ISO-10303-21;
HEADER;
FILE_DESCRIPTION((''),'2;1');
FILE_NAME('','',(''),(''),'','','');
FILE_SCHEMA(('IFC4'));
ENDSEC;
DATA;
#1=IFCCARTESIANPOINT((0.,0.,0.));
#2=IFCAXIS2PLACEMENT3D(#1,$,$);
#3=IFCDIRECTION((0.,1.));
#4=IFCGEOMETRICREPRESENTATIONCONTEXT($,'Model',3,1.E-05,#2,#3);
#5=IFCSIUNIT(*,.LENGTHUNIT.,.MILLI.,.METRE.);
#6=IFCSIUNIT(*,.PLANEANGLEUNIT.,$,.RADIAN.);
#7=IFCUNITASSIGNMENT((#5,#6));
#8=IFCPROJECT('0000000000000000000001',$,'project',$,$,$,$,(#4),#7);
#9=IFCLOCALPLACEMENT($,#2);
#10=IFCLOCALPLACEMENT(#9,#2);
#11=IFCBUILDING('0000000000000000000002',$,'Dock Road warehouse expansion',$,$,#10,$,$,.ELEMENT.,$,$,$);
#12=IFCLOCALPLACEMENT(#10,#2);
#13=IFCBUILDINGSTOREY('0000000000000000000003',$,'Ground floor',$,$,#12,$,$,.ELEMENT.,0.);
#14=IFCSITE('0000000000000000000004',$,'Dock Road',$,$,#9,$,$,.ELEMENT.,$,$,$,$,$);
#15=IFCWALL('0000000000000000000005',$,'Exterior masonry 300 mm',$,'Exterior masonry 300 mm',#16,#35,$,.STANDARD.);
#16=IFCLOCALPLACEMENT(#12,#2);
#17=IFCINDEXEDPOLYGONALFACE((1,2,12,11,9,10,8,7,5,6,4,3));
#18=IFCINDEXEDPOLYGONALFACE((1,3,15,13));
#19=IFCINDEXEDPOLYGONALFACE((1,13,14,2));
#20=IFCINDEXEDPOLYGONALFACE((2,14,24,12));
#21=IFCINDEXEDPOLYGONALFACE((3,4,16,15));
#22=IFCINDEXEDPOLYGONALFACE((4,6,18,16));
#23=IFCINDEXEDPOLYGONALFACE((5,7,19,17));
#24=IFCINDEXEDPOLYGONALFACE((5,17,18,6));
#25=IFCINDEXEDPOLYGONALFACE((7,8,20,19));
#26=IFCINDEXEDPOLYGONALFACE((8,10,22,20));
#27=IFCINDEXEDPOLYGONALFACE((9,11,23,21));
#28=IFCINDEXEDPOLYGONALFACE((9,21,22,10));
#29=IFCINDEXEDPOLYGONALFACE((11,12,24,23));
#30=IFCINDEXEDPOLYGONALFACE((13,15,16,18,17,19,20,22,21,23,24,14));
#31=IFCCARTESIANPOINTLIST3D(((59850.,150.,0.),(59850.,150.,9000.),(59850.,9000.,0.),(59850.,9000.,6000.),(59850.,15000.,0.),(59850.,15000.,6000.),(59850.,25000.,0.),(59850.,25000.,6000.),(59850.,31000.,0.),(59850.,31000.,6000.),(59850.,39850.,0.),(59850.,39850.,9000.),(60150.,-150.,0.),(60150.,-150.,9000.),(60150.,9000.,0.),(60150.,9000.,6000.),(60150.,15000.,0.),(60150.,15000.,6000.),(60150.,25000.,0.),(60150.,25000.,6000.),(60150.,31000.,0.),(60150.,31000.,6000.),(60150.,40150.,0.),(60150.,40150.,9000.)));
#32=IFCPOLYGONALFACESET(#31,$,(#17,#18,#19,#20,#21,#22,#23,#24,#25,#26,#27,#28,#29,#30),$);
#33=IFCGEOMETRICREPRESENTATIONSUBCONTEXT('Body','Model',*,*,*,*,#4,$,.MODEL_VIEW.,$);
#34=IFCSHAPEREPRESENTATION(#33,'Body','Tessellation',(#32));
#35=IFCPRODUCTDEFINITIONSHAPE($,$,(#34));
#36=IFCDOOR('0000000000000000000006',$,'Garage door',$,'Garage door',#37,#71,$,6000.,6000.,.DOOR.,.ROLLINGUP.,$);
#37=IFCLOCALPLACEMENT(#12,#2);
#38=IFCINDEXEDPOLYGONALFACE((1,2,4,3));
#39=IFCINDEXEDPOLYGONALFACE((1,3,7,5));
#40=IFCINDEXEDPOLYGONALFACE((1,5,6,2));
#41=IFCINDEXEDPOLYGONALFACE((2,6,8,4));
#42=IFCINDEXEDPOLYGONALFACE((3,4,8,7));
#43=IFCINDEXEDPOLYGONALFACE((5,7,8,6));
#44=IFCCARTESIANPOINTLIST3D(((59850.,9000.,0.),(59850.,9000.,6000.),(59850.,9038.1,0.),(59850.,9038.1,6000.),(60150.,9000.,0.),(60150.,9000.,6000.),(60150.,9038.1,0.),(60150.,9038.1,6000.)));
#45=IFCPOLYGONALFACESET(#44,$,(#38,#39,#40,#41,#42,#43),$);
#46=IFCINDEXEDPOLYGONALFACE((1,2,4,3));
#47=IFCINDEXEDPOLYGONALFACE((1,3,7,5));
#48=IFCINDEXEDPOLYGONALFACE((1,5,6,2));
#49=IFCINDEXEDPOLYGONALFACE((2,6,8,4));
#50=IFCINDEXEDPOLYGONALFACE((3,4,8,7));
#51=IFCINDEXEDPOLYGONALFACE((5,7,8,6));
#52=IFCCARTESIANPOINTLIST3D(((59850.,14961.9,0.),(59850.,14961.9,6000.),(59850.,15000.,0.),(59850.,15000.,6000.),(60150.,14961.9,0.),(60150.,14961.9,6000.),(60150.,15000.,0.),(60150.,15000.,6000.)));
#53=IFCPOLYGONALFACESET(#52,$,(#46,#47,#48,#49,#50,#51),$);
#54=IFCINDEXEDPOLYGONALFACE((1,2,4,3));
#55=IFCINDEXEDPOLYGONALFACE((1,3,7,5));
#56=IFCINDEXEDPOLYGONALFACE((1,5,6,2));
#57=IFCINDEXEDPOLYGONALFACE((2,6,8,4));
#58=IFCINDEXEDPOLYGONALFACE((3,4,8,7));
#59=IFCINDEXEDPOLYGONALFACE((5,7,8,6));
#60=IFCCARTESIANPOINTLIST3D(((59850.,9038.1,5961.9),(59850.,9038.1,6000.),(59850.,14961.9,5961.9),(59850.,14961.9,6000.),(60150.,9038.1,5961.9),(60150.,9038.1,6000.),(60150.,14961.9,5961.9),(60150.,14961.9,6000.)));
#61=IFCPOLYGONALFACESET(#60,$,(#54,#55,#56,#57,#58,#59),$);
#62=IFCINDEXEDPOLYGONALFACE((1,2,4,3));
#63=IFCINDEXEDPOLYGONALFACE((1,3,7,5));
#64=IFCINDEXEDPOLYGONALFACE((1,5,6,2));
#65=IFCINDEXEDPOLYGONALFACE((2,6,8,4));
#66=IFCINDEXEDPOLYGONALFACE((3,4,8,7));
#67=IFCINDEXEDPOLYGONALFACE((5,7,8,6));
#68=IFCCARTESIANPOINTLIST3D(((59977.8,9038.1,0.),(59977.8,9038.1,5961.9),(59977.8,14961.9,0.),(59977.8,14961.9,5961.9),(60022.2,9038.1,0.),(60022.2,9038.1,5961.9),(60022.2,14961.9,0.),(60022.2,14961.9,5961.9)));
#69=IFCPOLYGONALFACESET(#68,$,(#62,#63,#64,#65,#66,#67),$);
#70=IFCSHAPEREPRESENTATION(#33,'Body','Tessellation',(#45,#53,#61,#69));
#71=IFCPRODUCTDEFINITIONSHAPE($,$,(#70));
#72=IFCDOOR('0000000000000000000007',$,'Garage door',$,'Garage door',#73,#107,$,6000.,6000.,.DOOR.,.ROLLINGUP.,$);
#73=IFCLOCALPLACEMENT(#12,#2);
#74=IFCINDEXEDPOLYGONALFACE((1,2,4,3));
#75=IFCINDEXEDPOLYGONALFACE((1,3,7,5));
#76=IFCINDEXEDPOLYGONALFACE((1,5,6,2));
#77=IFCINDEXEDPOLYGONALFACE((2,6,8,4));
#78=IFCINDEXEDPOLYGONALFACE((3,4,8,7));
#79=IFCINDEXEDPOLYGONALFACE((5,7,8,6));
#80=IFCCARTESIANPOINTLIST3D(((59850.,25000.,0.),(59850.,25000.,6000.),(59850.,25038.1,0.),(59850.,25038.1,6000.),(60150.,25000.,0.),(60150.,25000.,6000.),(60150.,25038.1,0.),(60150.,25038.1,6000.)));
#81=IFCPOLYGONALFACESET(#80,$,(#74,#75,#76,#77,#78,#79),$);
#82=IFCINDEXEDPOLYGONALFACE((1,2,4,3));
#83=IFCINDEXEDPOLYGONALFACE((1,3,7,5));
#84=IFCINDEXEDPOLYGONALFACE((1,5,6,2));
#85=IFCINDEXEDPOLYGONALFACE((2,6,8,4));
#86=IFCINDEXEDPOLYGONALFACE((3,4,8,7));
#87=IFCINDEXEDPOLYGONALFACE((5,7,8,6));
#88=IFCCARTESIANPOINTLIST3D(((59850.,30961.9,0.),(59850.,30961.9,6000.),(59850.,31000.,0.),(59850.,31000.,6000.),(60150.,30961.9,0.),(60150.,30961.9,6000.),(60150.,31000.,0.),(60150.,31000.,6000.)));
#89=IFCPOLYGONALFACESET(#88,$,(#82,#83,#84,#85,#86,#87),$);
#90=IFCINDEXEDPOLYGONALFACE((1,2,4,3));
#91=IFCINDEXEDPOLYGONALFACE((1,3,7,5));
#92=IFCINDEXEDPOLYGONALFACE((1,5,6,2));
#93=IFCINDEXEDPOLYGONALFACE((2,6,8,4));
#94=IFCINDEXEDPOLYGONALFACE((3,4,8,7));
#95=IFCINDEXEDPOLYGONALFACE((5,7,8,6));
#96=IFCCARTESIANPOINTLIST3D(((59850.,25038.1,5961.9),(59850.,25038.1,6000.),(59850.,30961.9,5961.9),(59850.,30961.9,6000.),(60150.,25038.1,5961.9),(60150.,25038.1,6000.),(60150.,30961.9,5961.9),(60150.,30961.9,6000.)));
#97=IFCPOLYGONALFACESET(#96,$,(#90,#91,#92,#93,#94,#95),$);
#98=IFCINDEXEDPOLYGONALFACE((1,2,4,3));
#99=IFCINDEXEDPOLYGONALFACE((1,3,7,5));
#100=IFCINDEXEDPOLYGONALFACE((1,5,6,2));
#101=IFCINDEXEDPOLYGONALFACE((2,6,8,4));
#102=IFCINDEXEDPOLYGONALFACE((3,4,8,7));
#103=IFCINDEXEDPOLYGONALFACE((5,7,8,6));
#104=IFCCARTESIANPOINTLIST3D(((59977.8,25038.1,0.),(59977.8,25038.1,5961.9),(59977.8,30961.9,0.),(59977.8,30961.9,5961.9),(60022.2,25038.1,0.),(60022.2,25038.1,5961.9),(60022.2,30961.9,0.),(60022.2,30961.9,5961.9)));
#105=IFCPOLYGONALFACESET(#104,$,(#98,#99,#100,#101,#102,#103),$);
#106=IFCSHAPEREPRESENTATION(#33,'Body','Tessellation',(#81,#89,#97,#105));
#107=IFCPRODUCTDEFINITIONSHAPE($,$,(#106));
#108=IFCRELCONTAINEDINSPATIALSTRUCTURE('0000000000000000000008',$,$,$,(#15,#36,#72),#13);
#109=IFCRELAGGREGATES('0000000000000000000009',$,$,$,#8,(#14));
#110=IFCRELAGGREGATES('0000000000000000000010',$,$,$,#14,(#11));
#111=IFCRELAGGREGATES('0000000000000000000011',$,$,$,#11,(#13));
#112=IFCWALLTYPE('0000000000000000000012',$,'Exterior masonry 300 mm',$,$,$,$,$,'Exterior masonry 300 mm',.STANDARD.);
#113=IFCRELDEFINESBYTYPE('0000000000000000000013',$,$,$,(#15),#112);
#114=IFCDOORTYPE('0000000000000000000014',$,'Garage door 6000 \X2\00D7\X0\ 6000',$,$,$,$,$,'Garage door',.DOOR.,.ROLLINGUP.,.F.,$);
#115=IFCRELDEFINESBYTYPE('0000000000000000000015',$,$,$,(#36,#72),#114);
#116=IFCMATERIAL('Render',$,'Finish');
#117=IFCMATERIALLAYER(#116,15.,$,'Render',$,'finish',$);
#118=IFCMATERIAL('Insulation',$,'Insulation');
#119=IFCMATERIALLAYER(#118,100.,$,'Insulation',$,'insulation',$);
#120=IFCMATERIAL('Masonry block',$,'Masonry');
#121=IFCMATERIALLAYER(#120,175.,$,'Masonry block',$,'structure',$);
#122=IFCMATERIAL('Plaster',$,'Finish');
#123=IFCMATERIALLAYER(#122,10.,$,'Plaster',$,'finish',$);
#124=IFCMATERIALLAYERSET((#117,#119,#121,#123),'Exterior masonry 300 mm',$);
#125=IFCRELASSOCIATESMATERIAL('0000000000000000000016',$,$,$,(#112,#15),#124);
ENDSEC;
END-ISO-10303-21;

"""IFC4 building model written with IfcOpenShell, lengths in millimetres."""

from ifc_helpers import new_model, si_unit, direction, frame, origin, origin_with_axes, place, context, subcontext, project, spatial, polyline, outline, extrude, material, layer, layer_set, layer_usage, type_object, element, fill, save


model = new_model("IFC4")

# Units and contexts
model_context = context("Model", 3, precision=1e-05, world=origin(), true_north=direction((0.0, 1.0)))
body_context = subcontext(model_context, "Body", "Model", "MODEL_VIEW")
ifc_project = project(units=[si_unit("LENGTHUNIT", "METRE", prefix="MILLI"), si_unit("PLANEANGLEUNIT", "RADIAN")], contexts=[model_context])

# Site, building, storey
site_placement = place(None, origin())
site = spatial("IfcSite", under=ifc_project, at=site_placement, Name="Dock Road", CompositionType="ELEMENT")
building_placement = place(site_placement, origin())
building = spatial("IfcBuilding", under=site, at=building_placement, Name="Dock Road warehouse expansion", CompositionType="ELEMENT")
storey_placement = place(building_placement, origin())
storey = spatial("IfcBuildingStorey", under=building, at=storey_placement, Name="Ground floor", CompositionType="ELEMENT", Elevation=0.0)

# Shared definitions
ifc_material_1 = material(Name="Render", Category="Finish")
ifc_layer_1 = layer(ifc_material_1, 15.0, Name="Render", Category="finish")
ifc_material_2 = material(Name="Insulation", Category="Insulation")
ifc_layer_2 = layer(ifc_material_2, 100.0, Name="Insulation", Category="insulation")
ifc_material_3 = material(Name="Masonry block", Category="Masonry")
ifc_layer_3 = layer(ifc_material_3, 175.0, Name="Masonry block", Category="structure")
ifc_material_4 = material(Name="Plaster", Category="Finish")
ifc_layer_4 = layer(ifc_material_4, 10.0, Name="Plaster", Category="finish")
ifc_layer_set = layer_set([ifc_layer_1, ifc_layer_2, ifc_layer_3, ifc_layer_4], Name="Exterior masonry 300 mm")
wall_type = type_object("IfcWallType", Name="Exterior masonry 300 mm", ElementType="Exterior masonry 300 mm", PredefinedType="STANDARD", material=ifc_layer_set)

# Wall, openings, doors
ifc_layer_usage_1 = layer_usage(ifc_layer_set, "AXIS2", "POSITIVE", -150.0)
wall_1_placement = place(storey_placement, frame((60000.0, 0.0, 0.0), z_axis=(0.0, 0.0, 1.0), x_axis=(0.0, 1.0, 0.0)))
wall_1 = element("IfcWall", 1, at=wall_1_placement, inside=storey, type_object=wall_type, material=ifc_layer_usage_1, Name="Exterior masonry 300 mm", ObjectType="Exterior masonry 300 mm", PredefinedType="STANDARD", context=body_context, shape_type="SweptSolid", body=[
    extrude(outline(polyline([(-150.0, -150.0), (40150.0, -150.0), (39850.0, 150.0), (150.0, 150.0), (-150.0, -150.0)])), origin(), (0.0, 0.0, 1.0), 9000.0),
])
opening_1_placement = place(wall_1_placement, frame((9000.0, 0.0, 0.0), z_axis=(0.0, 0.0, 1.0), x_axis=(1.0, 0.0, 0.0)))
opening_1 = element("IfcOpeningElement", 2, at=opening_1_placement, cuts=wall_1, PredefinedType="OPENING", context=body_context, shape_type="SweptSolid", body=[
    extrude(outline(polyline([(0.0, -160.0), (6000.0, -160.0), (6000.0, 160.0), (0.0, 160.0), (0.0, -160.0)])), origin(), (0.0, 0.0, 1.0), 6000.0),
])
opening_2_placement = place(wall_1_placement, frame((25000.0, 0.0, 0.0), z_axis=(0.0, 0.0, 1.0), x_axis=(1.0, 0.0, 0.0)))
opening_2 = element("IfcOpeningElement", 3, at=opening_2_placement, cuts=wall_1, PredefinedType="OPENING", context=body_context, shape_type="SweptSolid", body=[
    extrude(outline(polyline([(0.0, -160.0), (6000.0, -160.0), (6000.0, 160.0), (0.0, 160.0), (0.0, -160.0)])), origin(), (0.0, 0.0, 1.0), 6000.0),
])
door_type_1 = type_object("IfcDoorType", Name="Garage door 6000 × 6000", ElementType="Garage door", OperationType="ROLLINGUP", ParameterTakesPrecedence=False, PredefinedType="DOOR")
door_1_placement = place(opening_1_placement, origin_with_axes())
door_1 = element("IfcDoor", 4, at=door_1_placement, inside=storey, type_object=door_type_1, Name="Garage door", ObjectType="Garage door", OperationType="ROLLINGUP", OverallHeight=6000.0, OverallWidth=6000.0, PredefinedType="DOOR", context=body_context, shape_type="SweptSolid", body=[
    extrude(outline(polyline([(0.0, -150.0), (38.1, -150.0), (38.1, 150.0), (0.0, 150.0), (0.0, -150.0)])), origin(), (0.0, 0.0, 1.0), 6000.0),
    extrude(outline(polyline([(5961.9, -150.0), (6000.0, -150.0), (6000.0, 150.0), (5961.9, 150.0), (5961.9, -150.0)])), origin(), (0.0, 0.0, 1.0), 6000.0),
    extrude(outline(polyline([(38.1, -150.0), (5961.9, -150.0), (5961.9, 150.0), (38.1, 150.0), (38.1, -150.0)])), frame((0.0, 0.0, 5961.9)), (0.0, 0.0, 1.0), 38.1),
    extrude(outline(polyline([(38.1, -22.2), (5961.9, -22.2), (5961.9, 22.2), (38.1, 22.2), (38.1, -22.2)])), origin(), (0.0, 0.0, 1.0), 5961.9),
])
fill(opening_1, door_1)
door_2_placement = place(opening_2_placement, origin_with_axes())
door_2 = element("IfcDoor", 5, at=door_2_placement, inside=storey, type_object=door_type_1, Name="Garage door", ObjectType="Garage door", OperationType="ROLLINGUP", OverallHeight=6000.0, OverallWidth=6000.0, PredefinedType="DOOR", context=body_context, shape_type="SweptSolid", body=[
    extrude(outline(polyline([(0.0, -150.0), (38.1, -150.0), (38.1, 150.0), (0.0, 150.0), (0.0, -150.0)])), origin(), (0.0, 0.0, 1.0), 6000.0),
    extrude(outline(polyline([(5961.9, -150.0), (6000.0, -150.0), (6000.0, 150.0), (5961.9, 150.0), (5961.9, -150.0)])), origin(), (0.0, 0.0, 1.0), 6000.0),
    extrude(outline(polyline([(38.1, -150.0), (5961.9, -150.0), (5961.9, 150.0), (38.1, 150.0), (38.1, -150.0)])), frame((0.0, 0.0, 5961.9)), (0.0, 0.0, 1.0), 38.1),
    extrude(outline(polyline([(38.1, -22.2), (5961.9, -22.2), (5961.9, 22.2), (38.1, 22.2), (38.1, -22.2)])), origin(), (0.0, 0.0, 1.0), 5961.9),
])
fill(opening_2, door_2)

save(model, "model.ifc")
